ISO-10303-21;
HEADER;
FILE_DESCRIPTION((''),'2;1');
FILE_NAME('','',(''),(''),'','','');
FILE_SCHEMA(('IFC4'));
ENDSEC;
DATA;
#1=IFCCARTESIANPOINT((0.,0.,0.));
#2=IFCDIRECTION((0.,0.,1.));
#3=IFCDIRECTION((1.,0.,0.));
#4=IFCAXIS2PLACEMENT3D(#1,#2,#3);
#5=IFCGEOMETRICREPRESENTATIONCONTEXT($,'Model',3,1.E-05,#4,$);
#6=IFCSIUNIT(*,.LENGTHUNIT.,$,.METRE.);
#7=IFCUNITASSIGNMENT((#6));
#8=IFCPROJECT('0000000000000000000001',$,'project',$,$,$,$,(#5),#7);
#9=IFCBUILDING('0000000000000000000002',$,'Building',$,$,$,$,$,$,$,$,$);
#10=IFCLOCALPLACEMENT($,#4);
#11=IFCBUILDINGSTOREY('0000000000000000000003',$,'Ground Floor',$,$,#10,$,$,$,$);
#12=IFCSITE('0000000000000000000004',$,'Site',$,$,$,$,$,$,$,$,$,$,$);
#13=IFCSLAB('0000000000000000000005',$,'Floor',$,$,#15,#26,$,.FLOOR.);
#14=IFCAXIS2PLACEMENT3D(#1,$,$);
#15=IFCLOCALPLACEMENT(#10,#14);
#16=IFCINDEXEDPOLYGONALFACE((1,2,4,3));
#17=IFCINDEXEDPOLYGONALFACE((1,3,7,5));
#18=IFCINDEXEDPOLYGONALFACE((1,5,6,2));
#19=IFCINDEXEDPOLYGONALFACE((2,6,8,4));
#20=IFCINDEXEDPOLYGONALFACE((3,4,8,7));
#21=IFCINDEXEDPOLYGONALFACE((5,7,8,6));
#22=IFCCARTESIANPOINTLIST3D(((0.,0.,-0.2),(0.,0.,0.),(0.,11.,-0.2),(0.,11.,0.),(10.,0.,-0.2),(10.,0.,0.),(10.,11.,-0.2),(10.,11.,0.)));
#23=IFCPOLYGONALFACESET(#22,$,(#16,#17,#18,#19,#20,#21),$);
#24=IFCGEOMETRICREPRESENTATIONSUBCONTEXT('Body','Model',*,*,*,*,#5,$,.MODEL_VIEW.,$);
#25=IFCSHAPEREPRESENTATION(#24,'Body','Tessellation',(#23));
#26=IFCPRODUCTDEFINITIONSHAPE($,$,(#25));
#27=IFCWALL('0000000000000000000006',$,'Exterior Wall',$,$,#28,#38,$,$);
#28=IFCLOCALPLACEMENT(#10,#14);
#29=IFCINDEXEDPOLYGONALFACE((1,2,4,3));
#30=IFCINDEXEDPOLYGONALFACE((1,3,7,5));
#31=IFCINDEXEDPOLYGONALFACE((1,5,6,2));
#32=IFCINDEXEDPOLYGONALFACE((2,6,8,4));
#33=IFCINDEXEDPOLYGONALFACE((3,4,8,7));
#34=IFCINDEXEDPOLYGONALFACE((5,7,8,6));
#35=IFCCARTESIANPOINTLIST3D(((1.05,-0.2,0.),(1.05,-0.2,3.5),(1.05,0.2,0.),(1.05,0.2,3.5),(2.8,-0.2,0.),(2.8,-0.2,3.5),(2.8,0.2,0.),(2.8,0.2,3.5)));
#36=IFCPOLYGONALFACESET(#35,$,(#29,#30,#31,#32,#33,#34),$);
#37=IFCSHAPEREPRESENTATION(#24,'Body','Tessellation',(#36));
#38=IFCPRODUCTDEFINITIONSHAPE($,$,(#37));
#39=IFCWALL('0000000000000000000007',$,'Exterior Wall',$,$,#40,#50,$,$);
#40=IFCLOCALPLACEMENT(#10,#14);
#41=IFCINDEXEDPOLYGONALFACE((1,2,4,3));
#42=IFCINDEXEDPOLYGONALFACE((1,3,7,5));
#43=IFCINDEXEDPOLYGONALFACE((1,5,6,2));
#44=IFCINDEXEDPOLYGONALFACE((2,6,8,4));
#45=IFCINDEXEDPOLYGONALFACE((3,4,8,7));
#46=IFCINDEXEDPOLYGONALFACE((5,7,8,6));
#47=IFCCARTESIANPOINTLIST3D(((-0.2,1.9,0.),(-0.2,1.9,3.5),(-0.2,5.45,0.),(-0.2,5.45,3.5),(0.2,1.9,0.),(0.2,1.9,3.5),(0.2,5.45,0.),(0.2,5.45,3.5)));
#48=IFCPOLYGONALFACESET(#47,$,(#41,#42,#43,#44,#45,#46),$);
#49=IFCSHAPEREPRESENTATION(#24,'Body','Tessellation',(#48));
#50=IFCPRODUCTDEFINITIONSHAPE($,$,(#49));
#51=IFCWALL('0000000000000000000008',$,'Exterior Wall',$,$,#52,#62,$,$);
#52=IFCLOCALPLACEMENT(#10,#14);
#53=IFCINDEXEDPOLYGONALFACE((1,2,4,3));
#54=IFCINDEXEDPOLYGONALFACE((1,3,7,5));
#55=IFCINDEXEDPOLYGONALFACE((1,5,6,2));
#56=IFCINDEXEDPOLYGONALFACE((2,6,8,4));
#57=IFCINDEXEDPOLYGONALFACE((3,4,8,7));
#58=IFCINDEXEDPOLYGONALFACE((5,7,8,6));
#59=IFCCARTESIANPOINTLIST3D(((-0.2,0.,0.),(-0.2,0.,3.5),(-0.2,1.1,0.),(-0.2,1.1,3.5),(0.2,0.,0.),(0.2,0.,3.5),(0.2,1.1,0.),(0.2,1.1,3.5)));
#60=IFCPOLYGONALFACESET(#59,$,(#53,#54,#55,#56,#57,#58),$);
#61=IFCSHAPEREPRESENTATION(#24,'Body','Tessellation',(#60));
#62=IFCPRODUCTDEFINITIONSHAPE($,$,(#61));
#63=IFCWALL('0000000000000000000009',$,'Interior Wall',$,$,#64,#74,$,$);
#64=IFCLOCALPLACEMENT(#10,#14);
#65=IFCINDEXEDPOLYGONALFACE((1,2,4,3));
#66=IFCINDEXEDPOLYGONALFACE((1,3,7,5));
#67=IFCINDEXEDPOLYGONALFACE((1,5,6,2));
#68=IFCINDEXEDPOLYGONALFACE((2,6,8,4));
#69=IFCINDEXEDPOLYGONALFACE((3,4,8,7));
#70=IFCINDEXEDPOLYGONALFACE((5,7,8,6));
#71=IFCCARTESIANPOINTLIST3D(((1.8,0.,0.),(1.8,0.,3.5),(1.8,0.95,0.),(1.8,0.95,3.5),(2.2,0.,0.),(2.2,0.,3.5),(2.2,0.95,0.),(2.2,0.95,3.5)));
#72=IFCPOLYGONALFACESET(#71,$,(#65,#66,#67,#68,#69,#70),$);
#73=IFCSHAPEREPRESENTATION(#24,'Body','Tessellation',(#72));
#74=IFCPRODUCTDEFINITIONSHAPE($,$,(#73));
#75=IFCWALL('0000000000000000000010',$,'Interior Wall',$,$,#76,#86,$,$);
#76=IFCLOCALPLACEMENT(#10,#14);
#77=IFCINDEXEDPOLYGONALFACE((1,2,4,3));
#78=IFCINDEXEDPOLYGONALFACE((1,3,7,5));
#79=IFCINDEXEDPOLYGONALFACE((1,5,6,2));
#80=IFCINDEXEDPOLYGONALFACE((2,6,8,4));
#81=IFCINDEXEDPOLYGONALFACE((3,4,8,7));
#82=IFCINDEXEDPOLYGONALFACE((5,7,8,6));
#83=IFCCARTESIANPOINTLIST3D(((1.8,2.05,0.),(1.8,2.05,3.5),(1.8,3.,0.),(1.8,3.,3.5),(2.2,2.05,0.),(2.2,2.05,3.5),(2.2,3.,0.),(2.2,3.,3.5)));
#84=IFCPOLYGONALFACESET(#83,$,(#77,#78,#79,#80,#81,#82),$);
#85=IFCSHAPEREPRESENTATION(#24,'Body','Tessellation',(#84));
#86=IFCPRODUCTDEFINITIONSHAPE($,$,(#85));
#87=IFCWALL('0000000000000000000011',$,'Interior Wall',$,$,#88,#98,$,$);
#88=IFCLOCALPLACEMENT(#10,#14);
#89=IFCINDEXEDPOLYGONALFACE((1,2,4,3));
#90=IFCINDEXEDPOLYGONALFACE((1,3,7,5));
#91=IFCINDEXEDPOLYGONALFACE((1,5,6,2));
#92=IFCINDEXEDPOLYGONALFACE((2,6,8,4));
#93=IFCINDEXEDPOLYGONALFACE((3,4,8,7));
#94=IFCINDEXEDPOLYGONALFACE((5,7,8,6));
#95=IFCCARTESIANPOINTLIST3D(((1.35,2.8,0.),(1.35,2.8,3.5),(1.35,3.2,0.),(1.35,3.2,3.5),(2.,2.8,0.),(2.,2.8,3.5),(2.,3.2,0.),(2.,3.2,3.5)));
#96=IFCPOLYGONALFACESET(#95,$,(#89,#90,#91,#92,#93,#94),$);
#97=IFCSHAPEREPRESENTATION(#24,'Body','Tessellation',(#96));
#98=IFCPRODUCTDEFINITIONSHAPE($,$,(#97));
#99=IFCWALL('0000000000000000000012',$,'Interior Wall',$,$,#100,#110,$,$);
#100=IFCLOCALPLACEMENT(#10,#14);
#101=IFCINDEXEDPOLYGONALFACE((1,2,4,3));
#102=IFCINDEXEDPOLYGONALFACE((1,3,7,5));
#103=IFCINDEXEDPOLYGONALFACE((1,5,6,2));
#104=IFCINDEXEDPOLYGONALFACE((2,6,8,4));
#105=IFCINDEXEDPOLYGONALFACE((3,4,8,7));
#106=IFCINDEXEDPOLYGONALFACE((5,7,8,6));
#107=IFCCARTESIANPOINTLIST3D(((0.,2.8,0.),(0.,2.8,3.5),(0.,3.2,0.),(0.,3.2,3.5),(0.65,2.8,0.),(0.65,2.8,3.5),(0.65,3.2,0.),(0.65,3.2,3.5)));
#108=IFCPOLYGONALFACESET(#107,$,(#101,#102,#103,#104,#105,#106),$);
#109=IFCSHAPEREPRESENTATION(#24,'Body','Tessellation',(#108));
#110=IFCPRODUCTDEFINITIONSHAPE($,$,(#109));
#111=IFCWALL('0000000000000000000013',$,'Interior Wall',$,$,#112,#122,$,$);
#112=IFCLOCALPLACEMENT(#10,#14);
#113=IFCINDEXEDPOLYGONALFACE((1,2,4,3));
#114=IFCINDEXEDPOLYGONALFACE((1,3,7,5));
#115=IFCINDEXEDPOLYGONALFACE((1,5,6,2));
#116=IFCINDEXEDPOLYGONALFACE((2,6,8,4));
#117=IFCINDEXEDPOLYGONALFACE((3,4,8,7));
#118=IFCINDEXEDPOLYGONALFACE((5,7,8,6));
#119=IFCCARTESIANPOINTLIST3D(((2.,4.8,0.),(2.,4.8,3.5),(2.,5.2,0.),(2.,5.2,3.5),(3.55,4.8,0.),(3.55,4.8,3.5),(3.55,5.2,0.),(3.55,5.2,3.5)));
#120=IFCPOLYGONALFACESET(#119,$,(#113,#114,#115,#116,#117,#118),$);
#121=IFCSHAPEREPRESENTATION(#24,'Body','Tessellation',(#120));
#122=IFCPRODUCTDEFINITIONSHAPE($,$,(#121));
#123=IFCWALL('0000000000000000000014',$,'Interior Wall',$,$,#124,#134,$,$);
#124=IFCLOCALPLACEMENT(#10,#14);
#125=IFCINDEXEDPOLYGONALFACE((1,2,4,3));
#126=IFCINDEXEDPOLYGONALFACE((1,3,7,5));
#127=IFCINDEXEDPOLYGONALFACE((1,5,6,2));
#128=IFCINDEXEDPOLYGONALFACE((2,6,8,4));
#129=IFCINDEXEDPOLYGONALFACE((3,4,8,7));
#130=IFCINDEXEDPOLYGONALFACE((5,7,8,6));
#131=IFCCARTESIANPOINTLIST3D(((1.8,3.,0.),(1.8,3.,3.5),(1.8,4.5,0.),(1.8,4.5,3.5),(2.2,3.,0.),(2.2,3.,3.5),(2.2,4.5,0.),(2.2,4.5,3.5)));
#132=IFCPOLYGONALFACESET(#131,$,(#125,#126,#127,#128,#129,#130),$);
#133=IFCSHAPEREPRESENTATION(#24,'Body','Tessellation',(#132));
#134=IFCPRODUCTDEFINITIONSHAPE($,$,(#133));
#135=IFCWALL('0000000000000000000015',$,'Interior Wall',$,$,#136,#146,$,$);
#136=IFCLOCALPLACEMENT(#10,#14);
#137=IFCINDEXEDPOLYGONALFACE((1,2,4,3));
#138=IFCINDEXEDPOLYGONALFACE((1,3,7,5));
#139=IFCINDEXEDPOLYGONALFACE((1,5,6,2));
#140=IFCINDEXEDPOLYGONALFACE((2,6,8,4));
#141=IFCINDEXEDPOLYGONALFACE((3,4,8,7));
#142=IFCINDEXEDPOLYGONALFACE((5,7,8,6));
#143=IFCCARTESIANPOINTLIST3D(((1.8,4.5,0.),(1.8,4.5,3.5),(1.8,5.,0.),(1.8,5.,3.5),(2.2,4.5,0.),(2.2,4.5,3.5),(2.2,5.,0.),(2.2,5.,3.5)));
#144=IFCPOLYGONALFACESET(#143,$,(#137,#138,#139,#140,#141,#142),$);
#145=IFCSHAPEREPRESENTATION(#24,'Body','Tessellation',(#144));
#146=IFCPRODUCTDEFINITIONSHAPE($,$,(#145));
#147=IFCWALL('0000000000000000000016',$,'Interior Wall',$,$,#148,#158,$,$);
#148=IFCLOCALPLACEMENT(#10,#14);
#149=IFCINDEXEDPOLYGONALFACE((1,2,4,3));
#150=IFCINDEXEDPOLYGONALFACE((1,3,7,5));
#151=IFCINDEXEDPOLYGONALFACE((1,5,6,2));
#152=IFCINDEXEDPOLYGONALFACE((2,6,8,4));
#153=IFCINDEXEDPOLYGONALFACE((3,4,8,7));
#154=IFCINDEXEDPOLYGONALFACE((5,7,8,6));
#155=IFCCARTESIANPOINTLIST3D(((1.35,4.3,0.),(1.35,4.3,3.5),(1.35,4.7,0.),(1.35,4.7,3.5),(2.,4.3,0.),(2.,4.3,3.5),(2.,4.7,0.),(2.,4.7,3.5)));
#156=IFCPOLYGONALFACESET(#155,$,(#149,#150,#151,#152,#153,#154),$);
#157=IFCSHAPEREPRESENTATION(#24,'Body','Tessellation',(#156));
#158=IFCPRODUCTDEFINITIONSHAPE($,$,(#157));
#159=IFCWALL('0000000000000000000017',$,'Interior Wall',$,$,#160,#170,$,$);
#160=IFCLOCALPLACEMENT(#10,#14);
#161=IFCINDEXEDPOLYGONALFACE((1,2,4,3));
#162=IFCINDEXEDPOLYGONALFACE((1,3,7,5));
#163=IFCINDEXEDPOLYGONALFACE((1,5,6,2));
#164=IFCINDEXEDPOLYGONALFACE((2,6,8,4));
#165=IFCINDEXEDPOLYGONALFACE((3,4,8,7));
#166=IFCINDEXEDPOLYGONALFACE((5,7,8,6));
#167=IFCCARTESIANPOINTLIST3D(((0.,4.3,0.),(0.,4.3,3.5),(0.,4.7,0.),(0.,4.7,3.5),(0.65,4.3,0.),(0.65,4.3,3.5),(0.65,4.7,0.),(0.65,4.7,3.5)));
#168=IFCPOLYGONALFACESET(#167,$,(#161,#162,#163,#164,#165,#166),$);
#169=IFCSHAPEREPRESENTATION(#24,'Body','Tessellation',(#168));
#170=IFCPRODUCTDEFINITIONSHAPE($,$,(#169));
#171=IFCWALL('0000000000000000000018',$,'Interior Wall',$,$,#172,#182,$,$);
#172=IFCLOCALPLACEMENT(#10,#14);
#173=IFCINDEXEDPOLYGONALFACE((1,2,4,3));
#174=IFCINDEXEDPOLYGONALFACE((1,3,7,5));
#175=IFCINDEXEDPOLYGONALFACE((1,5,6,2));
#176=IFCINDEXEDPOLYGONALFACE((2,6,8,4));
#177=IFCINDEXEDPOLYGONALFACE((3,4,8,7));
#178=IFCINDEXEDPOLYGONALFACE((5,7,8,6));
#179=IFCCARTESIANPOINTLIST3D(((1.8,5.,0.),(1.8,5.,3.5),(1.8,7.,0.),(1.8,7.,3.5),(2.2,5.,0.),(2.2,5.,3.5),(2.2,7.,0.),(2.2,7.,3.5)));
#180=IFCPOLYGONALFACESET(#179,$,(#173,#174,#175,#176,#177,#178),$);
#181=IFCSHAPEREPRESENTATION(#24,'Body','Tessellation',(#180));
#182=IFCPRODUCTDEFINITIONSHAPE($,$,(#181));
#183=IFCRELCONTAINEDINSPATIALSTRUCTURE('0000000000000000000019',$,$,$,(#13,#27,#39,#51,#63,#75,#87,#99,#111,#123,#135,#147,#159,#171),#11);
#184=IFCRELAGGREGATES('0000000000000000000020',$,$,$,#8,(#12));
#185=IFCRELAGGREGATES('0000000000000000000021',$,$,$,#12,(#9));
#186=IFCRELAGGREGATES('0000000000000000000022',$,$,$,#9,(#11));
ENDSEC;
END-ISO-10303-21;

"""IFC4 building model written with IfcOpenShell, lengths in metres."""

from ifc_helpers import new_model, si_unit, frame, origin_with_axes, place, context, subcontext, project, spatial, indexed_curve, outline, extrude, element, save


model = new_model("IFC4")

# Units and contexts
model_context = context("Model", 3, precision=1e-05, world=origin_with_axes())
body_context = subcontext(model_context, "Body", "Model", "MODEL_VIEW")
ifc_project = project(units=[si_unit("LENGTHUNIT", "METRE")], contexts=[model_context])

# Site, building, storey
site = spatial("IfcSite", under=ifc_project, Name="Site")
building = spatial("IfcBuilding", under=site, Name="Building")
storey_placement = place(None, origin_with_axes())
storey = spatial("IfcBuildingStorey", under=building, at=storey_placement, Name="Ground Floor")

# Slab
slab_placement = place(storey_placement, frame((0.0, 0.0, -0.2), z_axis=(0.0, 0.0, 1.0), x_axis=(1.0, 0.0, 0.0)))
element("IfcSlab", 1, at=slab_placement, inside=storey, Name="Floor", PredefinedType="FLOOR", context=body_context, shape_type="SweptSolid", body=[
    extrude(outline(indexed_curve([(0.0, 0.0), (10.0, 0.0), (10.0, 11.0), (0.0, 11.0)])), None, (0.0, 0.0, 1.0), 0.2),
])

# Walls
wall_1_placement = place(storey_placement, frame((1.05, 0.0, 0.0), z_axis=(0.0, 0.0, 1.0), x_axis=(1.0, 0.0, 0.0)))
element("IfcWall", 2, at=wall_1_placement, inside=storey, Name="Exterior Wall", context=body_context, shape_type="SweptSolid", body=[
    extrude(outline(indexed_curve([(0.0, 0.0), (0.0, 0.4), (1.75, 0.4), (1.75, 0.0), (0.0, 0.0)], self_intersect=False)), frame((0.0, -0.2, 0.0), z_axis=(0.0, 0.0, 1.0), x_axis=(1.0, 0.0, 0.0)), (0.0, 0.0, 1.0), 3.5),
])
wall_2_placement = place(storey_placement, frame((0.0, 5.45, 0.0), z_axis=(0.0, 0.0, 1.0), x_axis=(0.0, -1.0, 0.0)))
element("IfcWall", 3, at=wall_2_placement, inside=storey, Name="Exterior Wall", context=body_context, shape_type="SweptSolid", body=[
    extrude(outline(indexed_curve([(0.0, 0.0), (0.0, 0.4), (3.55, 0.4), (3.55, 0.0), (0.0, 0.0)], self_intersect=False)), frame((0.0, -0.2, 0.0), z_axis=(0.0, 0.0, 1.0), x_axis=(1.0, 0.0, 0.0)), (0.0, 0.0, 1.0), 3.5),
])
wall_3_placement = place(storey_placement, frame((0.0, 1.1, 0.0), z_axis=(0.0, 0.0, 1.0), x_axis=(0.0, -1.0, 0.0)))
element("IfcWall", 4, at=wall_3_placement, inside=storey, Name="Exterior Wall", context=body_context, shape_type="SweptSolid", body=[
    extrude(outline(indexed_curve([(0.0, 0.0), (0.0, 0.4), (1.1, 0.4), (1.1, 0.0), (0.0, 0.0)], self_intersect=False)), frame((0.0, -0.2, 0.0), z_axis=(0.0, 0.0, 1.0), x_axis=(1.0, 0.0, 0.0)), (0.0, 0.0, 1.0), 3.5),
])
wall_4_placement = place(storey_placement, frame((2.0, 0.0, 0.0), z_axis=(0.0, 0.0, 1.0), x_axis=(0.0, 1.0, 0.0)))
element("IfcWall", 5, at=wall_4_placement, inside=storey, Name="Interior Wall", context=body_context, shape_type="SweptSolid", body=[
    extrude(outline(indexed_curve([(0.0, 0.0), (0.0, 0.4), (0.95, 0.4), (0.95, 0.0), (0.0, 0.0)], self_intersect=False)), frame((0.0, -0.2, 0.0), z_axis=(0.0, 0.0, 1.0), x_axis=(1.0, 0.0, 0.0)), (0.0, 0.0, 1.0), 3.5),
])
wall_5_placement = place(storey_placement, frame((2.0, 2.05, 0.0), z_axis=(0.0, 0.0, 1.0), x_axis=(0.0, 1.0, 0.0)))
element("IfcWall", 6, at=wall_5_placement, inside=storey, Name="Interior Wall", context=body_context, shape_type="SweptSolid", body=[
    extrude(outline(indexed_curve([(0.0, 0.0), (0.0, 0.4), (0.95, 0.4), (0.95, 0.0), (0.0, 0.0)], self_intersect=False)), frame((0.0, -0.2, 0.0), z_axis=(0.0, 0.0, 1.0), x_axis=(1.0, 0.0, 0.0)), (0.0, 0.0, 1.0), 3.5),
])
for number, where, z_axis, x_axis, name in (
    (7, (2.0, 3.0, 0.0), (0.0, 0.0, 1.0), (-1.0, 0.0, 0.0), "Interior Wall"),
    (8, (0.65, 3.0, 0.0), (0.0, 0.0, 1.0), (-1.0, 0.0, 0.0), "Interior Wall"),
):
    element("IfcWall", number, at=place(storey_placement, frame(where, z_axis=z_axis, x_axis=x_axis)), inside=storey, Name=name, context=body_context, shape_type="SweptSolid", body=[
        extrude(outline(indexed_curve([(0.0, 0.0), (0.0, 0.4), (0.65, 0.4), (0.65, 0.0), (0.0, 0.0)], self_intersect=False)), frame((0.0, -0.2, 0.0), z_axis=(0.0, 0.0, 1.0), x_axis=(1.0, 0.0, 0.0)), (0.0, 0.0, 1.0), 3.5),
    ])
wall_6_placement = place(storey_placement, frame((3.55, 5.0, 0.0), z_axis=(0.0, 0.0, 1.0), x_axis=(-1.0, 0.0, 0.0)))
element("IfcWall", 9, at=wall_6_placement, inside=storey, Name="Interior Wall", context=body_context, shape_type="SweptSolid", body=[
    extrude(outline(indexed_curve([(0.0, 0.0), (0.0, 0.4), (1.55, 0.4), (1.55, 0.0), (0.0, 0.0)], self_intersect=False)), frame((0.0, -0.2, 0.0), z_axis=(0.0, 0.0, 1.0), x_axis=(1.0, 0.0, 0.0)), (0.0, 0.0, 1.0), 3.5),
])
wall_7_placement = place(storey_placement, frame((2.0, 4.5, 0.0), z_axis=(0.0, 0.0, 1.0), x_axis=(0.0, -1.0, 0.0)))
element("IfcWall", 10, at=wall_7_placement, inside=storey, Name="Interior Wall", context=body_context, shape_type="SweptSolid", body=[
    extrude(outline(indexed_curve([(0.0, 0.0), (0.0, 0.4), (1.5, 0.4), (1.5, 0.0), (0.0, 0.0)], self_intersect=False)), frame((0.0, -0.2, 0.0), z_axis=(0.0, 0.0, 1.0), x_axis=(1.0, 0.0, 0.0)), (0.0, 0.0, 1.0), 3.5),
])
wall_8_placement = place(storey_placement, frame((2.0, 5.0, 0.0), z_axis=(0.0, 0.0, 1.0), x_axis=(0.0, -1.0, 0.0)))
element("IfcWall", 11, at=wall_8_placement, inside=storey, Name="Interior Wall", context=body_context, shape_type="SweptSolid", body=[
    extrude(outline(indexed_curve([(0.0, 0.0), (0.0, 0.4), (0.5, 0.4), (0.5, 0.0), (0.0, 0.0)], self_intersect=False)), frame((0.0, -0.2, 0.0), z_axis=(0.0, 0.0, 1.0), x_axis=(1.0, 0.0, 0.0)), (0.0, 0.0, 1.0), 3.5),
])
for number, where, z_axis, x_axis, name in (
    (12, (2.0, 4.5, 0.0), (0.0, 0.0, 1.0), (-1.0, 0.0, 0.0), "Interior Wall"),
    (13, (0.65, 4.5, 0.0), (0.0, 0.0, 1.0), (-1.0, 0.0, 0.0), "Interior Wall"),
):
    element("IfcWall", number, at=place(storey_placement, frame(where, z_axis=z_axis, x_axis=x_axis)), inside=storey, Name=name, context=body_context, shape_type="SweptSolid", body=[
        extrude(outline(indexed_curve([(0.0, 0.0), (0.0, 0.4), (0.65, 0.4), (0.65, 0.0), (0.0, 0.0)], self_intersect=False)), frame((0.0, -0.2, 0.0), z_axis=(0.0, 0.0, 1.0), x_axis=(1.0, 0.0, 0.0)), (0.0, 0.0, 1.0), 3.5),
    ])
wall_9_placement = place(storey_placement, frame((2.0, 5.0, 0.0), z_axis=(0.0, 0.0, 1.0), x_axis=(0.0, 1.0, 0.0)))
element("IfcWall", 14, at=wall_9_placement, inside=storey, Name="Interior Wall", context=body_context, shape_type="SweptSolid", body=[
    extrude(outline(indexed_curve([(0.0, 0.0), (0.0, 0.4), (2.0, 0.4), (2.0, 0.0), (0.0, 0.0)], self_intersect=False)), frame((0.0, -0.2, 0.0), z_axis=(0.0, 0.0, 1.0), x_axis=(1.0, 0.0, 0.0)), (0.0, 0.0, 1.0), 3.5),
])

save(model, "model.ifc")
